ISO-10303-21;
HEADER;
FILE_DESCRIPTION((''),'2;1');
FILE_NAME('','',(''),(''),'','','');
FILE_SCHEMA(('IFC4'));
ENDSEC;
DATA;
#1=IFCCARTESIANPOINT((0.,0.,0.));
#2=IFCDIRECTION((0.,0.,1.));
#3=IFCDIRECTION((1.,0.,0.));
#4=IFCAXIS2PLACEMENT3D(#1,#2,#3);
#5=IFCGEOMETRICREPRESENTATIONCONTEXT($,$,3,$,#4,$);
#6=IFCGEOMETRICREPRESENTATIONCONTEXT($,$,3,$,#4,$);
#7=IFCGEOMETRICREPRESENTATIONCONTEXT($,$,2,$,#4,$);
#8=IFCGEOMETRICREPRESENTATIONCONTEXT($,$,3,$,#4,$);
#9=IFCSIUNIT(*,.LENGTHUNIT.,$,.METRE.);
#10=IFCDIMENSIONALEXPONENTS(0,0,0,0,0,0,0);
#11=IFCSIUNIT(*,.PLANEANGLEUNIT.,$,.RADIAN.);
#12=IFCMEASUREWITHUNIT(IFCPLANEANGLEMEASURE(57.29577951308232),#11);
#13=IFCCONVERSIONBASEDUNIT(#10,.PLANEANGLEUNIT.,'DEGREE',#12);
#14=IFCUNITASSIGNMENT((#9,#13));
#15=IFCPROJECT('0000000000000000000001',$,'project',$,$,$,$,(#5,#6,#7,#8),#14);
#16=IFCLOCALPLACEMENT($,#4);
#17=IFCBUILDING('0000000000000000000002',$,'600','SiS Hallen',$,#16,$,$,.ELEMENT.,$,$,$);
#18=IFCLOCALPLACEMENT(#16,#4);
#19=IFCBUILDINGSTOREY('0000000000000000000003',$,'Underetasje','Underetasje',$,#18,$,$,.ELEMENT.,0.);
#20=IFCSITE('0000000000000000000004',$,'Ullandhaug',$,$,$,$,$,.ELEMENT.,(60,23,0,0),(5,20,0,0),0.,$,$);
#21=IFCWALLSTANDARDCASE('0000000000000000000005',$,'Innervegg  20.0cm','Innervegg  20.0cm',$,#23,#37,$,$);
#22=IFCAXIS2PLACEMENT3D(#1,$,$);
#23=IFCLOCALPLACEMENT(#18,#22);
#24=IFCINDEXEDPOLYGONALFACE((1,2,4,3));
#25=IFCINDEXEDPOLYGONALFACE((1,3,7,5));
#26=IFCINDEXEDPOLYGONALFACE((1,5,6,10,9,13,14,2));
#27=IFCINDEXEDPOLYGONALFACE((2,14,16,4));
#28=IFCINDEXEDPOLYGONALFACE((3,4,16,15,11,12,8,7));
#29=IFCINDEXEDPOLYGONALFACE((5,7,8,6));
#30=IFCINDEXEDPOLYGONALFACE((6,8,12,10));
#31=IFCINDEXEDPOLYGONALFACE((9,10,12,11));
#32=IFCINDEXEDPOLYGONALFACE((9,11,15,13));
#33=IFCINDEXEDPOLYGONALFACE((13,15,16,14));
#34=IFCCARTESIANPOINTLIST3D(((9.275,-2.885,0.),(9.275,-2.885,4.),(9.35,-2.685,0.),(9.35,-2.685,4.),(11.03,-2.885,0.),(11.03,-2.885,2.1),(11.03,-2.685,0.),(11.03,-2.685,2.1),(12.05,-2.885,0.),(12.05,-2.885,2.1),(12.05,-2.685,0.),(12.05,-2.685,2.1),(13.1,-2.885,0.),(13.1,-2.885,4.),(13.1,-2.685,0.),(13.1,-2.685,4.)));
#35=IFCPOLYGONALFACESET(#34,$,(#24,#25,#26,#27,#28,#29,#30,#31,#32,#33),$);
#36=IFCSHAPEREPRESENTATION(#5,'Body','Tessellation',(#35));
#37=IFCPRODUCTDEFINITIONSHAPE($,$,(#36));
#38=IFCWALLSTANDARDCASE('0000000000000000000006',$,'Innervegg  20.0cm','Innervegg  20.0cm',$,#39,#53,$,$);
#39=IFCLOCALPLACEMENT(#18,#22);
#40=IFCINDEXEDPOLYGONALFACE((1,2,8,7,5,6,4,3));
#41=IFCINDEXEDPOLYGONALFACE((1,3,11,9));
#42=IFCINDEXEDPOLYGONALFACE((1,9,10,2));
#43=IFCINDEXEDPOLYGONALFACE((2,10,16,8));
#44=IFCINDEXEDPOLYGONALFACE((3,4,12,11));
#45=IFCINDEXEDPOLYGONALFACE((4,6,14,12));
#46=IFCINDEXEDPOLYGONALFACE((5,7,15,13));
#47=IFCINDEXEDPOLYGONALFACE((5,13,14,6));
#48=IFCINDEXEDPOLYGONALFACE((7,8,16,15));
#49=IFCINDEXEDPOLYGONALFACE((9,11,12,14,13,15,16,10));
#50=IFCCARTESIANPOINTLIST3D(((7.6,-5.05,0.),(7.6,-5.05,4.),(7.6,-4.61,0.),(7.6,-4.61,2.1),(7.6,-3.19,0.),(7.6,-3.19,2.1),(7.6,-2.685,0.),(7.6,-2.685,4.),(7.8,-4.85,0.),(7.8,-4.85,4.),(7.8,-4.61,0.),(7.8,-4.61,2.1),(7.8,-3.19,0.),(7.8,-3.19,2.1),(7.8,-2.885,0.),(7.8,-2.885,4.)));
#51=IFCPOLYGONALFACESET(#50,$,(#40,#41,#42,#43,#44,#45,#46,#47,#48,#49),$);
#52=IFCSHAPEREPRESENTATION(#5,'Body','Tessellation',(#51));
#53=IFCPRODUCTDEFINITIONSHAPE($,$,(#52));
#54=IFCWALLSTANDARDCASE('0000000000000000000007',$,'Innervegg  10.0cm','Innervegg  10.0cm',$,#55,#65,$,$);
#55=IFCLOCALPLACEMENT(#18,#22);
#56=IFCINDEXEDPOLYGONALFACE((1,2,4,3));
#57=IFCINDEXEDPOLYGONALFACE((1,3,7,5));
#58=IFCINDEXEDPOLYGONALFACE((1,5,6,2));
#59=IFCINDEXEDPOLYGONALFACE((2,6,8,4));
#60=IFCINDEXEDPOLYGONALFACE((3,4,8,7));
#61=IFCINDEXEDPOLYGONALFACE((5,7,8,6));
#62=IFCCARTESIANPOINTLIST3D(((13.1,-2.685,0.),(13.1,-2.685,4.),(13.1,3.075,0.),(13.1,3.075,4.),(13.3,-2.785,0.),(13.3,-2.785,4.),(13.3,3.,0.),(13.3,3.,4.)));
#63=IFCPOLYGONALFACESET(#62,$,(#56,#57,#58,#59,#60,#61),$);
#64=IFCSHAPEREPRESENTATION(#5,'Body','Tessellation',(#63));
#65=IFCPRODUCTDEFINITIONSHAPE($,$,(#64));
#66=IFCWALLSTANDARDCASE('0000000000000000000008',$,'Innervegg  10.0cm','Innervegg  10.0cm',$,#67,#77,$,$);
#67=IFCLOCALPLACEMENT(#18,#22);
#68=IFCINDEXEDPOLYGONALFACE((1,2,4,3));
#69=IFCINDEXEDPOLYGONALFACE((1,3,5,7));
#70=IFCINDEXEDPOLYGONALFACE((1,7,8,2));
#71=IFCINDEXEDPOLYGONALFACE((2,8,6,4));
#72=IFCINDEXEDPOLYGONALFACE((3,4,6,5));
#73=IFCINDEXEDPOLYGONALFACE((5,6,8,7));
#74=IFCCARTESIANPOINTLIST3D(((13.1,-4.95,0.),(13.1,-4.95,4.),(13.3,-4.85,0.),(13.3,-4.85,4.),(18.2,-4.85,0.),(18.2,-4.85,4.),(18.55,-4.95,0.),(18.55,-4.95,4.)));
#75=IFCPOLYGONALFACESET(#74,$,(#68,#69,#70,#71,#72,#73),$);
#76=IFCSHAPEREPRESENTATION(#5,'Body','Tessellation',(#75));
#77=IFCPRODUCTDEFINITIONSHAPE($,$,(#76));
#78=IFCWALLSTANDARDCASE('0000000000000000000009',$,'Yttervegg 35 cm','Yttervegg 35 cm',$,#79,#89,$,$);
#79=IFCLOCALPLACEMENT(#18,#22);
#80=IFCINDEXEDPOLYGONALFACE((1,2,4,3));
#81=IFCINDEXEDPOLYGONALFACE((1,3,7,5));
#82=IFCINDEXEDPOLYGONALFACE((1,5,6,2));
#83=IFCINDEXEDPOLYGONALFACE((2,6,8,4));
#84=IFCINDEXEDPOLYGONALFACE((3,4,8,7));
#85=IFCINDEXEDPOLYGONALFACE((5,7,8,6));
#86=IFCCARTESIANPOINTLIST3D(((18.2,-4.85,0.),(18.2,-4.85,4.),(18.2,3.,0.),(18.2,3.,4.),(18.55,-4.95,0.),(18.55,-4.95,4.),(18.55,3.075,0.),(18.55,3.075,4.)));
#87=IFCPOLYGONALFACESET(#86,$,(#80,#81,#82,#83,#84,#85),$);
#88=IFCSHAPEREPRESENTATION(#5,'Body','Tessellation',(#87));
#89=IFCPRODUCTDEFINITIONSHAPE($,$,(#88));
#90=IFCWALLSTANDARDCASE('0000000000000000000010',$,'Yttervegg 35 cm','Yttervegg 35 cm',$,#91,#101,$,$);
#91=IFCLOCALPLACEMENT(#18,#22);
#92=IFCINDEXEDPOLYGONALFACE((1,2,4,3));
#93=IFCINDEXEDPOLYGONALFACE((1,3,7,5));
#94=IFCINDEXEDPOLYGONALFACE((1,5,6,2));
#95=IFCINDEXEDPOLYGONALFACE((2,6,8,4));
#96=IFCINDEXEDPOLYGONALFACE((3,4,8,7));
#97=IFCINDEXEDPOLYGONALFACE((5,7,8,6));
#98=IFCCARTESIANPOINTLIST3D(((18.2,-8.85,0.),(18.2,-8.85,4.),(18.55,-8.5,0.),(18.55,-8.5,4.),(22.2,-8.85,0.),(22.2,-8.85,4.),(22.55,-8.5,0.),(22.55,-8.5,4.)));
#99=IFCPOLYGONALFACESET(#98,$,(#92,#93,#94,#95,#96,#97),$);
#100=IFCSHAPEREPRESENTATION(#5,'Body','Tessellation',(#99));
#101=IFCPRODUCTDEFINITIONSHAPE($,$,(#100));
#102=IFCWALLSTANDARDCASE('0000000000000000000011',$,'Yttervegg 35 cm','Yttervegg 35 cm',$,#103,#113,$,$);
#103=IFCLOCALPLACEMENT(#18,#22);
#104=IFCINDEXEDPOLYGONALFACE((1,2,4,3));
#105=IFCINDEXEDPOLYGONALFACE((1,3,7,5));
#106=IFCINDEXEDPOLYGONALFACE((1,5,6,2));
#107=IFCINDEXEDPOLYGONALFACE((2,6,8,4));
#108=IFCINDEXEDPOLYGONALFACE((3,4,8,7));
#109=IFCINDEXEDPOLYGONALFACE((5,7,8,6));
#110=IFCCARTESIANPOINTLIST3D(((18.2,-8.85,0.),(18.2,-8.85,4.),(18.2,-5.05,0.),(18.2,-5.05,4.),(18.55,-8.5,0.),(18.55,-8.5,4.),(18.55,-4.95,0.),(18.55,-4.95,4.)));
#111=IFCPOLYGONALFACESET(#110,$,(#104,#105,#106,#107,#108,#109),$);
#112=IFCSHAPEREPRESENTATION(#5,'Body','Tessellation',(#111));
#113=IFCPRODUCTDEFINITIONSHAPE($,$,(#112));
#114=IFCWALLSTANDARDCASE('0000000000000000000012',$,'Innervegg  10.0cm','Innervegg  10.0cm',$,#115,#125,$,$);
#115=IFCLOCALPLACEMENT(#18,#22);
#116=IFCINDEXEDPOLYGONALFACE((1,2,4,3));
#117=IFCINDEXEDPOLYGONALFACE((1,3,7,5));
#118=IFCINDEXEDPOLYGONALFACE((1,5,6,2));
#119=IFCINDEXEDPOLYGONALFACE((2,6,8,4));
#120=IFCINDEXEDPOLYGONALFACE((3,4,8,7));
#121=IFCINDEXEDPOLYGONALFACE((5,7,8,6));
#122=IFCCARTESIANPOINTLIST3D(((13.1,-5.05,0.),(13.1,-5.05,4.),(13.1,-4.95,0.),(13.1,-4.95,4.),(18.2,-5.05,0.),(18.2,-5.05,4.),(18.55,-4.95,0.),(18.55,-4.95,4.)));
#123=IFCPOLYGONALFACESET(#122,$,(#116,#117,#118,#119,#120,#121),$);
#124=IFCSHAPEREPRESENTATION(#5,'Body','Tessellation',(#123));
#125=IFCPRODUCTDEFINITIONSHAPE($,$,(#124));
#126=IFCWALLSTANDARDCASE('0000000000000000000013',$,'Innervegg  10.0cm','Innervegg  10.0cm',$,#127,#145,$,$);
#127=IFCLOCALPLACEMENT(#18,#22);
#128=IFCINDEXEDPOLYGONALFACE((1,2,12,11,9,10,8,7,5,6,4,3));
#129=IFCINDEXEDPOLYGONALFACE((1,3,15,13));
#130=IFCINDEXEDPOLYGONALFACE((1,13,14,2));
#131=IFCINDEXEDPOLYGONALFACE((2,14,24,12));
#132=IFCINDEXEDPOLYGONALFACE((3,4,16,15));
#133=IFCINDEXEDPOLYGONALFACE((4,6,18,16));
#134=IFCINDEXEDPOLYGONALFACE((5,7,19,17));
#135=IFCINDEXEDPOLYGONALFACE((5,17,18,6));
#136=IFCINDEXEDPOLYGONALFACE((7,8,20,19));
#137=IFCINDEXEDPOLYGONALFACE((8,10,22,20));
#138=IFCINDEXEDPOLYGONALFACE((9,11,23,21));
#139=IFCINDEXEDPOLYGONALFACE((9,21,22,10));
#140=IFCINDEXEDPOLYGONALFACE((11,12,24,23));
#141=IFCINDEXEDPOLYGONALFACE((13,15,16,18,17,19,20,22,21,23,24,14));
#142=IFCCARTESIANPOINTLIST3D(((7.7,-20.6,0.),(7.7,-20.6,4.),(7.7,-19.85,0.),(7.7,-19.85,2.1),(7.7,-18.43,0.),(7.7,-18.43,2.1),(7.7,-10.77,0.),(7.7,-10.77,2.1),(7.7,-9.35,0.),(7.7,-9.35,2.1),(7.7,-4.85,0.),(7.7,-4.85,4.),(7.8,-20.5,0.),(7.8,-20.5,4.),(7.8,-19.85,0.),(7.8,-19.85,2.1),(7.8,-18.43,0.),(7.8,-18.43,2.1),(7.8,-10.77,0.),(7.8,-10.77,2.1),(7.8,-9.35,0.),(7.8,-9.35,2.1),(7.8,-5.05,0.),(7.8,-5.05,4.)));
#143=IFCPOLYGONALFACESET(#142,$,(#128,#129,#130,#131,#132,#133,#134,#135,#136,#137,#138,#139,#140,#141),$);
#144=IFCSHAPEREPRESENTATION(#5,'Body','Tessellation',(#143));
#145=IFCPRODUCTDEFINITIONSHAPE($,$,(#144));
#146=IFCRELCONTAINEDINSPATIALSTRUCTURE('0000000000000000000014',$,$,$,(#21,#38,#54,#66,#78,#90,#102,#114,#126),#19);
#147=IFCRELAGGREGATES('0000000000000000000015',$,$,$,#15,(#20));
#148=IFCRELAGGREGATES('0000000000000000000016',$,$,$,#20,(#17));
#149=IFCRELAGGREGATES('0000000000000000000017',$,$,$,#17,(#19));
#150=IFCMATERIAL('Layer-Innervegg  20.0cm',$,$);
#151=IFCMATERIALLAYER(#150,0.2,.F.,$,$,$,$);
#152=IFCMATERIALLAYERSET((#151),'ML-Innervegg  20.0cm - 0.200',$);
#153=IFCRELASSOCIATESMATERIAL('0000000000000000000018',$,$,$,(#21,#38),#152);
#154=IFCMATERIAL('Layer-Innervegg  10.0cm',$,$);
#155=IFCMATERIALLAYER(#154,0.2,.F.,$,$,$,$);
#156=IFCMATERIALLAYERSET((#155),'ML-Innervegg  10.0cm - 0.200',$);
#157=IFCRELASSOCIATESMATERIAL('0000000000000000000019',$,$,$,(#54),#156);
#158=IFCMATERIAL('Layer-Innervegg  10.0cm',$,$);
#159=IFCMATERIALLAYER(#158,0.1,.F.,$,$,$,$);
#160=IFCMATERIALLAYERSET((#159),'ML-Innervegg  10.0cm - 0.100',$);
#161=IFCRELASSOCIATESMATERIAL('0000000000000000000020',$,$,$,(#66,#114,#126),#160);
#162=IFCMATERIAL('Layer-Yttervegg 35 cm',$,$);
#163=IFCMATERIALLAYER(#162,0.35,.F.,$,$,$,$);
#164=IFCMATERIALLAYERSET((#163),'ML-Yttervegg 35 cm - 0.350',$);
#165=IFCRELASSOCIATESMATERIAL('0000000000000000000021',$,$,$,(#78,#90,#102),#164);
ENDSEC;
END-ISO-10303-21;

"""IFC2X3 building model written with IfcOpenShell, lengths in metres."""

from ifc_helpers import new_model, entity, si_unit, converted_unit, frame, origin_with_axes, place, context, project, spatial, polyline, outline, extrude, material, layer, layer_set, layer_usage, element, save


model = new_model("IFC2X3")

# Units and contexts
context_of_model_1 = context(None, 3, world=origin_with_axes())
context_of_model_2 = context(None, 3, world=origin_with_axes())
context_of_model_3 = context(None, 2, world=origin_with_axes())
context_of_model_4 = context(None, 3, world=origin_with_axes())
ifc_project = project(units=[si_unit("LENGTHUNIT", "METRE"), converted_unit("PLANEANGLEUNIT", "DEGREE", entity("IfcPlaneAngleMeasure", 57.29577951308232), si_unit("PLANEANGLEUNIT", "RADIAN"), dimensions=[0, 0, 0, 0, 0, 0, 0])], contexts=[context_of_model_1, context_of_model_2, context_of_model_3, context_of_model_4])

# Site, building, storey
site = spatial("IfcSite", under=ifc_project, Name="Ullandhaug", CompositionType="ELEMENT", RefLatitude=(60, 23, 0, 0), RefLongitude=(5, 20, 0, 0), RefElevation=0.0)
building_placement = place(None, origin_with_axes())
building = spatial("IfcBuilding", under=site, at=building_placement, Name="600", Description="SiS Hallen", CompositionType="ELEMENT")
storey_placement = place(building_placement, origin_with_axes())
storey = spatial("IfcBuildingStorey", under=building, at=storey_placement, Name="Underetasje", Description="Underetasje", CompositionType="ELEMENT", Elevation=0.0)

# Shared definitions
ifc_material_1 = material(Name="Layer-Innervegg  10.0cm")
ifc_layer_1 = layer(ifc_material_1, 0.1, ventilated=False)
ifc_layer_set_1 = layer_set([ifc_layer_1], Name="ML-Innervegg  10.0cm - 0.100")
ifc_layer_usage_1 = layer_usage(ifc_layer_set_1, "AXIS2", "POSITIVE", 0.0)
ifc_material_2 = material(Name="Layer-Innervegg  10.0cm")
ifc_layer_2 = layer(ifc_material_2, 0.2, ventilated=False)
ifc_layer_set_2 = layer_set([ifc_layer_2], Name="ML-Innervegg  10.0cm - 0.200")
ifc_layer_usage_2 = layer_usage(ifc_layer_set_2, "AXIS2", "POSITIVE", 0.0)

# Shared definitions
ifc_material_3 = material(Name="Layer-Innervegg  20.0cm")
ifc_layer_3 = layer(ifc_material_3, 0.2, ventilated=False)
ifc_layer_set_3 = layer_set([ifc_layer_3], Name="ML-Innervegg  20.0cm - 0.200")
ifc_layer_usage_3 = layer_usage(ifc_layer_set_3, "AXIS2", "POSITIVE", 0.0)

# Walls, openings
wall_1_placement = place(storey_placement, frame((13.1, -2.685, 0.0), z_axis=(0.0, 0.0, 1.0), x_axis=(-1.0, 0.0, 0.0)))
wall_1 = element("IfcWallStandardCase", 1, at=wall_1_placement, inside=storey, material=ifc_layer_usage_3, Name="Innervegg  20.0cm", Description="Innervegg  20.0cm", context=context_of_model_1, shape_type="SweptSolid", body=[
    extrude(outline(polyline([(0.0, 0.0), (3.75, 0.0), (3.825, 0.2), (0.0, 0.2), (0.0, 0.0)])), frame((0.0, 0.0, 0.0), z_axis=(0.0, 0.0, 1.0), x_axis=(1.0, 0.0, 0.0)), (0.0, 0.0, 1.0), 4.0),
])
opening_1_placement = place(wall_1_placement, frame((1.05, 0.2, 0.0), z_axis=(0.0, 0.0, 1.0), x_axis=(1.0, 0.0, 0.0)))
element("IfcOpeningElement", 2, at=opening_1_placement, cuts=wall_1, context=context_of_model_1, shape_type="SweptSolid", body=[
    extrude(outline(polyline([(0.0, 0.0), (2.1, 0.0), (2.1, 1.02), (0.0, 1.02), (0.0, 0.0)])), frame((0.0, 0.0, 0.0), z_axis=(0.0, 1.0, 0.0), x_axis=(0.0, 0.0, 1.0)), (0.0, 0.0, -1.0), 0.2),
])
wall_2_placement = place(storey_placement, frame((7.6, -2.685, 0.0), z_axis=(0.0, 0.0, 1.0), x_axis=(0.0, -1.0, 0.0)))
wall_2 = element("IfcWallStandardCase", 3, at=wall_2_placement, inside=storey, material=ifc_layer_usage_3, Name="Innervegg  20.0cm", Description="Innervegg  20.0cm", context=context_of_model_1, shape_type="SweptSolid", body=[
    extrude(outline(polyline([(0.0, 0.0), (2.365, 0.0), (2.165, 0.2), (0.2, 0.2), (0.0, 0.0)])), frame((0.0, 0.0, 0.0), z_axis=(0.0, 0.0, 1.0), x_axis=(1.0, 0.0, 0.0)), (0.0, 0.0, 1.0), 4.0),
])
opening_2_placement = place(wall_2_placement, frame((0.505, 0.2, 0.0), z_axis=(0.0, 0.0, 1.0), x_axis=(1.0, 0.0, 0.0)))
element("IfcOpeningElement", 4, at=opening_2_placement, cuts=wall_2, context=context_of_model_1, shape_type="SweptSolid", body=[
    extrude(outline(polyline([(0.0, 0.0), (2.1, 0.0), (2.1, 1.42), (0.0, 1.42), (0.0, 0.0)])), frame((0.0, 0.0, 0.0), z_axis=(0.0, 1.0, 0.0), x_axis=(0.0, 0.0, 1.0)), (0.0, 0.0, -1.0), 0.2),
])

# Walls
wall_3_placement = place(storey_placement, frame((13.3, -2.785, 0.0), z_axis=(0.0, 0.0, 1.0), x_axis=(0.0, 1.0, 0.0)))
element("IfcWallStandardCase", 5, at=wall_3_placement, inside=storey, material=ifc_layer_usage_2, Name="Innervegg  10.0cm", Description="Innervegg  10.0cm", context=context_of_model_1, shape_type="SweptSolid", body=[
    extrude(outline(polyline([(0.0, 0.0), (5.785, 0.0), (5.86, 0.2), (0.1, 0.2), (0.0, 0.0)])), frame((0.0, 0.0, 0.0), z_axis=(0.0, 0.0, 1.0), x_axis=(1.0, 0.0, 0.0)), (0.0, 0.0, 1.0), 4.0),
])
wall_4_placement = place(storey_placement, frame((13.1, -4.95, 0.0), z_axis=(0.0, 0.0, 1.0), x_axis=(1.0, 0.0, 0.0)))
element("IfcWallStandardCase", 6, at=wall_4_placement, inside=storey, material=ifc_layer_usage_1, Name="Innervegg  10.0cm", Description="Innervegg  10.0cm", context=context_of_model_1, shape_type="SweptSolid", body=[
    extrude(outline(polyline([(0.0, 0.0), (5.45, 0.0), (5.1, 0.1), (0.2, 0.1), (0.0, 0.0)])), origin_with_axes(), (0.0, 0.0, 1.0), 4.0),
])
ifc_material_4 = material(Name="Layer-Yttervegg 35 cm")
ifc_layer_4 = layer(ifc_material_4, 0.35, ventilated=False)
ifc_layer_set_4 = layer_set([ifc_layer_4], Name="ML-Yttervegg 35 cm - 0.350")
ifc_layer_usage_4 = layer_usage(ifc_layer_set_4, "AXIS2", "POSITIVE", 0.0)
wall_5_placement = place(storey_placement, frame((18.55, -4.95, 0.0), z_axis=(0.0, 0.0, 1.0), x_axis=(0.0, 1.0, 0.0)))
element("IfcWallStandardCase", 7, at=wall_5_placement, inside=storey, material=ifc_layer_usage_4, Name="Yttervegg 35 cm", Description="Yttervegg 35 cm", context=context_of_model_1, shape_type="SweptSolid", body=[
    extrude(outline(polyline([(0.0, 0.0), (8.025, 0.0), (7.95, 0.35), (0.1, 0.35), (0.0, 0.0)])), frame((0.0, 0.0, 0.0), z_axis=(0.0, 0.0, 1.0), x_axis=(1.0, 0.0, 0.0)), (0.0, 0.0, 1.0), 4.0),
])
wall_6_placement = place(storey_placement, frame((22.55, -8.5, 0.0), z_axis=(0.0, 0.0, 1.0), x_axis=(-1.0, 0.0, 0.0)))
element("IfcWallStandardCase", 8, at=wall_6_placement, inside=storey, material=ifc_layer_usage_4, Name="Yttervegg 35 cm", Description="Yttervegg 35 cm", context=context_of_model_1, shape_type="SweptSolid", body=[
    extrude(outline(polyline([(0.0, 0.0), (4.0, 0.0), (4.35, 0.35), (0.35, 0.35), (0.0, 0.0)])), frame((0.0, 0.0, 0.0), z_axis=(0.0, 0.0, 1.0), x_axis=(1.0, 0.0, 0.0)), (0.0, 0.0, 1.0), 4.0),
])
wall_7_placement = place(storey_placement, frame((18.55, -8.5, 0.0), z_axis=(0.0, 0.0, 1.0), x_axis=(0.0, 1.0, 0.0)))
element("IfcWallStandardCase", 9, at=wall_7_placement, inside=storey, material=ifc_layer_usage_4, Name="Yttervegg 35 cm", Description="Yttervegg 35 cm", context=context_of_model_1, shape_type="SweptSolid", body=[
    extrude(outline(polyline([(0.0, 0.0), (3.55, 0.0), (3.45, 0.35), (-0.35, 0.35), (0.0, 0.0)])), frame((0.0, 0.0, 0.0), z_axis=(0.0, 0.0, 1.0), x_axis=(1.0, 0.0, 0.0)), (0.0, 0.0, 1.0), 4.0),
])
wall_8_placement = place(storey_placement, frame((18.55, -4.95, 0.0), z_axis=(0.0, 0.0, 1.0), x_axis=(-1.0, 0.0, 0.0)))
element("IfcWallStandardCase", 10, at=wall_8_placement, inside=storey, material=ifc_layer_usage_1, Name="Innervegg  10.0cm", Description="Innervegg  10.0cm", context=context_of_model_1, shape_type="SweptSolid", body=[
    extrude(outline(polyline([(0.0, 0.0), (5.45, 0.0), (5.45, 0.1), (0.35, 0.1), (0.0, 0.0)])), frame((0.0, 0.0, 0.0), z_axis=(0.0, 0.0, 1.0), x_axis=(1.0, 0.0, 0.0)), (0.0, 0.0, 1.0), 4.0),
])

# Wall, openings
wall_9_placement = place(storey_placement, frame((7.7, -4.85, 0.0), z_axis=(0.0, 0.0, 1.0), x_axis=(0.0, -1.0, 0.0)))
wall_9 = element("IfcWallStandardCase", 11, at=wall_9_placement, inside=storey, material=ifc_layer_usage_1, Name="Innervegg  10.0cm", Description="Innervegg  10.0cm", context=context_of_model_1, shape_type="SweptSolid", body=[
    extrude(outline(polyline([(0.0, 0.0), (15.75, 0.0), (15.65, 0.1), (0.2, 0.1), (0.0, 0.0)])), frame((0.0, 0.0, 0.0), z_axis=(0.0, 0.0, 1.0), x_axis=(1.0, 0.0, 0.0)), (0.0, 0.0, 1.0), 4.0),
])
opening_3_placement = place(wall_9_placement, frame((13.58, 0.1, 0.0), z_axis=(0.0, 0.0, 1.0), x_axis=(1.0, 0.0, 0.0)))
element("IfcOpeningElement", 12, at=opening_3_placement, cuts=wall_9, context=context_of_model_1, shape_type="SweptSolid", body=[
    extrude(outline(polyline([(0.0, 0.0), (2.1, 0.0), (2.1, 1.42), (0.0, 1.42), (0.0, 0.0)])), frame((0.0, 0.0, 0.0), z_axis=(0.0, 1.0, 0.0), x_axis=(0.0, 0.0, 1.0)), (0.0, 0.0, -1.0), 0.1),
])
opening_4_placement = place(wall_9_placement, frame((4.5, 0.1, 0.0), z_axis=(0.0, 0.0, 1.0), x_axis=(1.0, 0.0, 0.0)))
element("IfcOpeningElement", 13, at=opening_4_placement, cuts=wall_9, context=context_of_model_1, shape_type="SweptSolid", body=[
    extrude(outline(polyline([(0.0, 0.0), (2.1, 0.0), (2.1, 1.42), (0.0, 1.42), (0.0, 0.0)])), frame((0.0, 0.0, 0.0), z_axis=(0.0, 1.0, 0.0), x_axis=(0.0, 0.0, 1.0)), (0.0, 0.0, -1.0), 0.1),
])

save(model, "model.ifc")
